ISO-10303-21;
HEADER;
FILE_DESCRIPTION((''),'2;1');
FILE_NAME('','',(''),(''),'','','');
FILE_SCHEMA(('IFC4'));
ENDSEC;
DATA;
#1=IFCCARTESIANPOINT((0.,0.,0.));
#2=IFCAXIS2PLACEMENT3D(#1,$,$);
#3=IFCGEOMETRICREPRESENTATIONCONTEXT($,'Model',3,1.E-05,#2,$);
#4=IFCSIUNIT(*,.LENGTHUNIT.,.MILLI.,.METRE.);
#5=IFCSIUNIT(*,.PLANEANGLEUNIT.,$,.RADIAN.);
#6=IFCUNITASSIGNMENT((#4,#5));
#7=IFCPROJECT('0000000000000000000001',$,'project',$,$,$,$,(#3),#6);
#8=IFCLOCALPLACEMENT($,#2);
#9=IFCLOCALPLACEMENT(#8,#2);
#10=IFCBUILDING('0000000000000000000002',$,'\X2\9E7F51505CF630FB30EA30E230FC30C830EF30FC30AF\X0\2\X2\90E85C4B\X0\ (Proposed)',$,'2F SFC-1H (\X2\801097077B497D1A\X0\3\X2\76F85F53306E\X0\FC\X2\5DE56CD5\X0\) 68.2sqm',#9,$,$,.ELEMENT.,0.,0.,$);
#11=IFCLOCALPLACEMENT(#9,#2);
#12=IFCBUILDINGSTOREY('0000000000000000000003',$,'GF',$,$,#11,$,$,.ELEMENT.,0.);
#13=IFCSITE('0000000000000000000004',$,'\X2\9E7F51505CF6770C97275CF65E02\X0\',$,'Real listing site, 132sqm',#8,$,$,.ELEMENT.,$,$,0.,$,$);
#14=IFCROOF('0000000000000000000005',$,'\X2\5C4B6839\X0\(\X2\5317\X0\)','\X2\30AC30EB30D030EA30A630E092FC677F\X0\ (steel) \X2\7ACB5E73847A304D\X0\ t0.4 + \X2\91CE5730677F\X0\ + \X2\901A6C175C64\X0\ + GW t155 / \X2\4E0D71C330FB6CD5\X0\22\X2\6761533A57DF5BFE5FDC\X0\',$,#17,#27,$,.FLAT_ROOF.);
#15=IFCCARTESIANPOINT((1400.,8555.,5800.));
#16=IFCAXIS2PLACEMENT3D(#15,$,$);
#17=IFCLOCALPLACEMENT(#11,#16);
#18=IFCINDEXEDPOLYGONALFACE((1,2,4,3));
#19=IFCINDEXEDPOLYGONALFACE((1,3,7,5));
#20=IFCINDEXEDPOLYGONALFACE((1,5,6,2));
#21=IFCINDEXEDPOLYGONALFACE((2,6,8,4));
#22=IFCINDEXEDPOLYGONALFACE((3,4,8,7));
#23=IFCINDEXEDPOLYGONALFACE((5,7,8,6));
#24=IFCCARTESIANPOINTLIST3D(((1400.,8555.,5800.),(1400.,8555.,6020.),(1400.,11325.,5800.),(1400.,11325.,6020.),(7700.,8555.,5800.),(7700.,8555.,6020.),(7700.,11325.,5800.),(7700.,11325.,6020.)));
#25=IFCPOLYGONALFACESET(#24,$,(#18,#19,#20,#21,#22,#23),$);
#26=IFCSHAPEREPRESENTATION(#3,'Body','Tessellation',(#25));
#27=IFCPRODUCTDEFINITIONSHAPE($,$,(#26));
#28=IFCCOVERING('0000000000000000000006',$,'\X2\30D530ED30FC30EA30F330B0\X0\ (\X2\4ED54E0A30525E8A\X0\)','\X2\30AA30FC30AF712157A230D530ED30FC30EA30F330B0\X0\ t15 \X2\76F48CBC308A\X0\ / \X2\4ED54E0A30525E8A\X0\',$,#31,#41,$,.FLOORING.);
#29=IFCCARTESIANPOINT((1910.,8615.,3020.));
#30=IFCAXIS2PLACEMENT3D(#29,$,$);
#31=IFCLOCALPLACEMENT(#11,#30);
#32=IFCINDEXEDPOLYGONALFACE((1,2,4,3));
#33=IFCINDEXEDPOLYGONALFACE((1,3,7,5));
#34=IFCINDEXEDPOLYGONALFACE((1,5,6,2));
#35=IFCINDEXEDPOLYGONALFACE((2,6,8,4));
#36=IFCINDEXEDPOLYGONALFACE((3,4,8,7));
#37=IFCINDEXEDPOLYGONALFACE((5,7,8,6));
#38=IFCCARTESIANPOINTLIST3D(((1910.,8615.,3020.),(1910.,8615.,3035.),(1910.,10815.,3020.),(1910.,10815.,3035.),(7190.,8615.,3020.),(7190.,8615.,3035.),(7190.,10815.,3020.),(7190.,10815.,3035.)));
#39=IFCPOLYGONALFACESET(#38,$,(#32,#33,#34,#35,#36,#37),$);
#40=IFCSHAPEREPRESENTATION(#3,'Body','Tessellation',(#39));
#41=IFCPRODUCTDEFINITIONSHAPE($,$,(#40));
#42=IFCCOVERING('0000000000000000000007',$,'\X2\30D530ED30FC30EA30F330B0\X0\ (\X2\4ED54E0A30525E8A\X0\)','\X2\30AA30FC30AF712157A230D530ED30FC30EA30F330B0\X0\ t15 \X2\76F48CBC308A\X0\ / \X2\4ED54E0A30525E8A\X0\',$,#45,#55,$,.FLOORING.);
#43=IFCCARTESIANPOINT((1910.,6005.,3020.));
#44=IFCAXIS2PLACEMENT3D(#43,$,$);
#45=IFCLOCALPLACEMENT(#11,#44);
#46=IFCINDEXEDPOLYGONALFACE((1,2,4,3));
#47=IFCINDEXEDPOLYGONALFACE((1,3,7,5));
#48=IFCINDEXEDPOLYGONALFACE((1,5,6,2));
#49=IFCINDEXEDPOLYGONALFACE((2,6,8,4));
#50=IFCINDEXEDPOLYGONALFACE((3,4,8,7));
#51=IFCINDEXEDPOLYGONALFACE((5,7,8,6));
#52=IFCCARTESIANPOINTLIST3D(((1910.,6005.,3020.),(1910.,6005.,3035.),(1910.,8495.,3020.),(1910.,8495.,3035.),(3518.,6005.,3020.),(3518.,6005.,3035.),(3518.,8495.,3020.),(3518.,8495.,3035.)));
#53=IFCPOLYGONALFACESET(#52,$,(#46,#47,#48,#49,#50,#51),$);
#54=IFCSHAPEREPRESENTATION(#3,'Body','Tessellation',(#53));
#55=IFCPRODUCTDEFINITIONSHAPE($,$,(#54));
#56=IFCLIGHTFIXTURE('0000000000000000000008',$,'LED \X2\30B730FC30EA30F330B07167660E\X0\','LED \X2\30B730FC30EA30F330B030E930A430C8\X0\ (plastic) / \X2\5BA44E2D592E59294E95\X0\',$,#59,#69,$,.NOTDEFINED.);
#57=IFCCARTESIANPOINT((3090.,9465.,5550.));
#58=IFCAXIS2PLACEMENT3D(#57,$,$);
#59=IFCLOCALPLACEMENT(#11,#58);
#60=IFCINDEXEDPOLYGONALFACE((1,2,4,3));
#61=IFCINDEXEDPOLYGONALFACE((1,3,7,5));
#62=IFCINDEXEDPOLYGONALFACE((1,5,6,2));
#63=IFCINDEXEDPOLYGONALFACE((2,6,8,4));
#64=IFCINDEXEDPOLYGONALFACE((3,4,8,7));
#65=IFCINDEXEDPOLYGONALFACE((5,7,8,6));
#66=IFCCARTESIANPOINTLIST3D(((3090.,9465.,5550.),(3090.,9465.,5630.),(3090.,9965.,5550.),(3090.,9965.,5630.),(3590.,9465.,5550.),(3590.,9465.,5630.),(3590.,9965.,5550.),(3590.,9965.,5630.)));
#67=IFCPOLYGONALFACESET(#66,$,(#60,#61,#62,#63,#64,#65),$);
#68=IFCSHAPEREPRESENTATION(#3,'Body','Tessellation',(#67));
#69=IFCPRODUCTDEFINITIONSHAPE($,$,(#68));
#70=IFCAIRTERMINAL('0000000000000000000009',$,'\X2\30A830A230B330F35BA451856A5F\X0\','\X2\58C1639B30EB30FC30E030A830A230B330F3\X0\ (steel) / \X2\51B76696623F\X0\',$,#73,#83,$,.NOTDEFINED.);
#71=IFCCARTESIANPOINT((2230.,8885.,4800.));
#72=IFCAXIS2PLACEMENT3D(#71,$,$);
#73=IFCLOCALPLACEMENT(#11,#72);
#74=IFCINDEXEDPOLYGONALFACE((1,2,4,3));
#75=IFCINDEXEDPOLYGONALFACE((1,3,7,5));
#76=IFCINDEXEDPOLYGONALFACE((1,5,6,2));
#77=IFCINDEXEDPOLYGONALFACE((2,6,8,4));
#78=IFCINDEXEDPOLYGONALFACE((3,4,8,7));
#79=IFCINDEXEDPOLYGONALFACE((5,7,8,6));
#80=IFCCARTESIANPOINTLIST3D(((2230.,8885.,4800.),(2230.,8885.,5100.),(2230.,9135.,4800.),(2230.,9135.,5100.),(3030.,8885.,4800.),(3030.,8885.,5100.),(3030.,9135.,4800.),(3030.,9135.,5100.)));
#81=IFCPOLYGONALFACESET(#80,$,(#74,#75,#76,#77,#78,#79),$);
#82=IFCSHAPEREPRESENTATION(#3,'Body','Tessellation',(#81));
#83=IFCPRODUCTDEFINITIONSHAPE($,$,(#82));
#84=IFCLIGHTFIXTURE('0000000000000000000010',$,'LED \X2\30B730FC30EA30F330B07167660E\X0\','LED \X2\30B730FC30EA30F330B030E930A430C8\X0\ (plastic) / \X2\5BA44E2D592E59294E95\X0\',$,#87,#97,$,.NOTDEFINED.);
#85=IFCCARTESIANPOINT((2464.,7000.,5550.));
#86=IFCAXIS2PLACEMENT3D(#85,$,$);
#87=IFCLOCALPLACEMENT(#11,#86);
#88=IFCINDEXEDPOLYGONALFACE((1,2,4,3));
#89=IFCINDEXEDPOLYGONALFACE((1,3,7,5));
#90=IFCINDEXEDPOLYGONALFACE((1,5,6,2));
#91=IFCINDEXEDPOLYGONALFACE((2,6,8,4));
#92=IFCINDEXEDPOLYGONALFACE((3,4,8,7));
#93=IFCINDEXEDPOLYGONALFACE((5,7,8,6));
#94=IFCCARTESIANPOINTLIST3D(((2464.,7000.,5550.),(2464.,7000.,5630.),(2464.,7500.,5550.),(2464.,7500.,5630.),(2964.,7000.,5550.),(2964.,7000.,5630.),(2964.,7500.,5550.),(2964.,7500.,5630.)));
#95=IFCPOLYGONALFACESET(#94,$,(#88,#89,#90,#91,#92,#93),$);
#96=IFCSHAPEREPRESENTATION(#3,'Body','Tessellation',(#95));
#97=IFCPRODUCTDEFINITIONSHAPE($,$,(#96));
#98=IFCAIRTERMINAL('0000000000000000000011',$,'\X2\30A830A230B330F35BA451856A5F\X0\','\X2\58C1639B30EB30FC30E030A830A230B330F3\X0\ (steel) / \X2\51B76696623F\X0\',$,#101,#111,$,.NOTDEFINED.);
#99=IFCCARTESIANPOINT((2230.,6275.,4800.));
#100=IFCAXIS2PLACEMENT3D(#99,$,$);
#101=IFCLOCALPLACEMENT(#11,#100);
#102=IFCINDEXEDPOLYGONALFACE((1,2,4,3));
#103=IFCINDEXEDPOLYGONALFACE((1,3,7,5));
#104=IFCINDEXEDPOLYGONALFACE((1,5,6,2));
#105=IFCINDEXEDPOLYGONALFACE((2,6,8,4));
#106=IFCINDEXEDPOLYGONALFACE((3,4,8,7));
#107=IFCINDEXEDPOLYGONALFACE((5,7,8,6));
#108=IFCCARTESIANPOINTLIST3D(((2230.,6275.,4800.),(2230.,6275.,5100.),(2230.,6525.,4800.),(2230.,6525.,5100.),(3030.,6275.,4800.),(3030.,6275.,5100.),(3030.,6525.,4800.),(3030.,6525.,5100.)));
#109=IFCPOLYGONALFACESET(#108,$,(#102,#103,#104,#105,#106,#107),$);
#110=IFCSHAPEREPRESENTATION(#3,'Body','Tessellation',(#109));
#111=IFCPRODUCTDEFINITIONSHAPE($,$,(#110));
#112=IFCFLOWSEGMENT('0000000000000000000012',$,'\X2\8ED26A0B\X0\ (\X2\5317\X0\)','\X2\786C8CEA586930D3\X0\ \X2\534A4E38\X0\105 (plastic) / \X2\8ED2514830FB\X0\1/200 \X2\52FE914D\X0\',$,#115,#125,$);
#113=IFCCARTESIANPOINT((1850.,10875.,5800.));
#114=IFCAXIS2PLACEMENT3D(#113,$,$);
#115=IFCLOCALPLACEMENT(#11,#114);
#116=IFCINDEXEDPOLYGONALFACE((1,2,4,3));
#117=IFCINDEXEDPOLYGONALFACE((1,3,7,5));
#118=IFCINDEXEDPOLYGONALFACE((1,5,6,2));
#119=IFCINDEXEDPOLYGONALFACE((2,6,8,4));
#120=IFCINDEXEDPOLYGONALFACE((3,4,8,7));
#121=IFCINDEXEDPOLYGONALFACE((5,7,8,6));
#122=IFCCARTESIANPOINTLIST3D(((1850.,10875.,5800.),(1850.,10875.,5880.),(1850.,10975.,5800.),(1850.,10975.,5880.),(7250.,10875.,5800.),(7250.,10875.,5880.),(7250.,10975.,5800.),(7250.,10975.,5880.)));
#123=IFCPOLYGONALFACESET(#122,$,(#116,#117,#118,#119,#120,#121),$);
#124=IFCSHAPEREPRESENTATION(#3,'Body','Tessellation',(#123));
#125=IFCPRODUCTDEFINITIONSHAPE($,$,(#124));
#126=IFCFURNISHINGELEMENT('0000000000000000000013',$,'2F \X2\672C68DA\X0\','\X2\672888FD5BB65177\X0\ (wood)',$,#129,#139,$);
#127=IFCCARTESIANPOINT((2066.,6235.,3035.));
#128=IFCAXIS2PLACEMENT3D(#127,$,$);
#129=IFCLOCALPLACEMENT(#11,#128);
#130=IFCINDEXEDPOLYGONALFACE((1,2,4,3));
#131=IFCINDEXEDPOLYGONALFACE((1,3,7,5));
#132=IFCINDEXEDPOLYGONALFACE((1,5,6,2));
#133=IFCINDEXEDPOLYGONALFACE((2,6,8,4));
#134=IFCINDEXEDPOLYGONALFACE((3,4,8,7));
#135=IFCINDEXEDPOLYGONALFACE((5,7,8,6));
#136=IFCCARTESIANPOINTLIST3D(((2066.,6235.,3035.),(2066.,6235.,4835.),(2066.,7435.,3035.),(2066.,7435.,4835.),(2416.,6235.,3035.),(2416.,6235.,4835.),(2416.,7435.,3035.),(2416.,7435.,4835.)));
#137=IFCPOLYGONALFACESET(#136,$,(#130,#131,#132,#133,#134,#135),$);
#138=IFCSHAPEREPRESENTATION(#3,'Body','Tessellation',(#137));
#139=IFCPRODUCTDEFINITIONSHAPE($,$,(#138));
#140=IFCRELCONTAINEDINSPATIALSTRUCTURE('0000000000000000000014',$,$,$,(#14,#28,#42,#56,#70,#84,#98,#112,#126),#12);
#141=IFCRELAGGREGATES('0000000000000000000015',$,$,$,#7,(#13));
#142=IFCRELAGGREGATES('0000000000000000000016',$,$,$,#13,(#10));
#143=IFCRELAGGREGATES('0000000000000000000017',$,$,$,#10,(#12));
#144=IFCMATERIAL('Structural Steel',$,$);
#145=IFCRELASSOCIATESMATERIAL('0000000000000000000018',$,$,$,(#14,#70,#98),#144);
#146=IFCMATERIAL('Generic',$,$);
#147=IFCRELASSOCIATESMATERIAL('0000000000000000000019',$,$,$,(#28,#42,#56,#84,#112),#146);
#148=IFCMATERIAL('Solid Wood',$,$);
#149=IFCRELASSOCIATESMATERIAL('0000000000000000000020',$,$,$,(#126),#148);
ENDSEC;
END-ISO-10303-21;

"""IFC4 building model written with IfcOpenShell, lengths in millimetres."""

from ifc_helpers import new_model, si_unit, frame, frame_2d, origin, place, context, project, spatial, rectangle, extrude, material, element, save


model = new_model("IFC4")

# Units and contexts
model_context = context("Model", 3, precision=1e-05, world=origin())
ifc_project = project(units=[si_unit("LENGTHUNIT", "METRE", prefix="MILLI"), si_unit("PLANEANGLEUNIT", "RADIAN")], contexts=[model_context])

# Site, building, storey
site_placement = place(None, origin())
site = spatial("IfcSite", under=ifc_project, at=site_placement, Name="鹿児島県霧島市", ObjectType="Real listing site, 132sqm", CompositionType="ELEMENT", RefElevation=0.0)
building_placement = place(site_placement, origin())
building = spatial("IfcBuilding", under=site, at=building_placement, Name="鹿児島・リモートワーク2部屋 (Proposed)", ObjectType="2F SFC-1H (耐震等級3相当のFC工法) 68.2sqm", CompositionType="ELEMENT", ElevationOfRefHeight=0.0, ElevationOfTerrain=0.0)
storey_placement = place(building_placement, origin())
storey = spatial("IfcBuildingStorey", under=building, at=storey_placement, Name="GF", CompositionType="ELEMENT", Elevation=0.0)

# Shared definitions
ifc_material_1 = material(Name="Solid Wood")

# Roof
ifc_material_2 = material(Name="Structural Steel")
for number, where, name in (
    (1, (1400.0, 8555.0, 5800.0), "屋根(北)"),
):
    element("IfcRoof", number, at=place(storey_placement, frame(where)), inside=storey, material=ifc_material_2, Name=name, Description="ガルバリウム鋼板 (steel) 立平葺き t0.4 + 野地板 + 通気層 + GW t155 / 不燃・法22条区域対応", PredefinedType="FLAT_ROOF", context=model_context, shape_type="SweptSolid", body=[
        extrude(rectangle(XDim=6300.0, YDim=2770.0, at=frame_2d((3150.0, 1385.0))), frame((1400.0, 8555.0, 5800.0)), (0.0, 0.0, 1.0), 220.0),
    ])

# Coverings
ifc_material_3 = material(Name="Generic")
covering_1_placement = place(storey_placement, frame((1910.0, 8615.0, 3020.0)))
element("IfcCovering", 2, at=covering_1_placement, inside=storey, material=ifc_material_3, Name="フローリング (仕上げ床)", Description="オーク無垢フローリング t15 直貼り / 仕上げ床", PredefinedType="FLOORING", context=model_context, shape_type="SweptSolid", body=[
    extrude(rectangle(XDim=5280.0, YDim=2200.0, at=frame_2d((2640.0, 1100.0))), frame((1910.0, 8615.0, 3020.0)), (0.0, 0.0, 1.0), 15.0),
])
covering_2_placement = place(storey_placement, frame((1910.0, 6005.0, 3020.0)))
element("IfcCovering", 3, at=covering_2_placement, inside=storey, material=ifc_material_3, Name="フローリング (仕上げ床)", Description="オーク無垢フローリング t15 直貼り / 仕上げ床", PredefinedType="FLOORING", context=model_context, shape_type="SweptSolid", body=[
    extrude(rectangle(XDim=1608.0, YDim=2490.0, at=frame_2d((804.0, 1245.0))), frame((1910.0, 6005.0, 3020.0)), (0.0, 0.0, 1.0), 15.0),
])

# Light fixture
light_fixture_1_placement = place(storey_placement, frame((3090.0, 9465.0, 5550.0)))
element("IfcLightFixture", 4, at=light_fixture_1_placement, inside=storey, material=ifc_material_3, Name="LED シーリング照明", Description="LED シーリングライト (plastic) / 室中央天井", PredefinedType="NOTDEFINED", context=model_context, shape_type="SweptSolid", body=[
    extrude(rectangle(XDim=500.0, YDim=500.0, at=frame_2d((250.0, 250.0))), frame((3090.0, 9465.0, 5550.0)), (0.0, 0.0, 1.0), 80.0),
])

# Air terminal
air_terminal_1_placement = place(storey_placement, frame((2230.0, 8885.0, 4800.0)))
element("IfcAirTerminal", 5, at=air_terminal_1_placement, inside=storey, material=ifc_material_2, Name="エアコン室内機", Description="壁掛ルームエアコン (steel) / 冷暖房", PredefinedType="NOTDEFINED", context=model_context, shape_type="SweptSolid", body=[
    extrude(rectangle(XDim=800.0, YDim=250.0, at=frame_2d((400.0, 125.0))), frame((2230.0, 8885.0, 4800.0)), (0.0, 0.0, 1.0), 300.0),
])

# Light fixture
light_fixture_2_placement = place(storey_placement, frame((2464.0, 7000.0, 5550.0)))
element("IfcLightFixture", 6, at=light_fixture_2_placement, inside=storey, material=ifc_material_3, Name="LED シーリング照明", Description="LED シーリングライト (plastic) / 室中央天井", PredefinedType="NOTDEFINED", context=model_context, shape_type="SweptSolid", body=[
    extrude(rectangle(XDim=500.0, YDim=500.0, at=frame_2d((250.0, 250.0))), frame((2464.0, 7000.0, 5550.0)), (0.0, 0.0, 1.0), 80.0),
])

# Air terminal
air_terminal_2_placement = place(storey_placement, frame((2230.0, 6275.0, 4800.0)))
element("IfcAirTerminal", 7, at=air_terminal_2_placement, inside=storey, material=ifc_material_2, Name="エアコン室内機", Description="壁掛ルームエアコン (steel) / 冷暖房", PredefinedType="NOTDEFINED", context=model_context, shape_type="SweptSolid", body=[
    extrude(rectangle(XDim=800.0, YDim=250.0, at=frame_2d((400.0, 125.0))), frame((2230.0, 6275.0, 4800.0)), (0.0, 0.0, 1.0), 300.0),
])

# Flow segment
flow_segment_placement = place(storey_placement, frame((1850.0, 10875.0, 5800.0)))
element("IfcFlowSegment", 8, at=flow_segment_placement, inside=storey, material=ifc_material_3, Name="軒樋 (北)", Description="硬質塩ビ 半丸105 (plastic) / 軒先・1/200 勾配", context=model_context, shape_type="SweptSolid", body=[
    extrude(rectangle(XDim=5400.0, YDim=100.0, at=frame_2d((2700.0, 50.0))), frame((1850.0, 10875.0, 5800.0)), (0.0, 0.0, 1.0), 80.0),
])

# Furnishing element
furnishing_placement = place(storey_placement, frame((2066.0, 6235.0, 3035.0)))
element("IfcFurnishingElement", 9, at=furnishing_placement, inside=storey, material=ifc_material_1, Name="2F 本棚", Description="木製家具 (wood)", context=model_context, shape_type="SweptSolid", body=[
    extrude(rectangle(XDim=350.0, YDim=1200.0, at=frame_2d((175.0, 600.0))), frame((2066.0, 6235.0, 3035.0)), (0.0, 0.0, 1.0), 1800.0),
])

save(model, "model.ifc")
